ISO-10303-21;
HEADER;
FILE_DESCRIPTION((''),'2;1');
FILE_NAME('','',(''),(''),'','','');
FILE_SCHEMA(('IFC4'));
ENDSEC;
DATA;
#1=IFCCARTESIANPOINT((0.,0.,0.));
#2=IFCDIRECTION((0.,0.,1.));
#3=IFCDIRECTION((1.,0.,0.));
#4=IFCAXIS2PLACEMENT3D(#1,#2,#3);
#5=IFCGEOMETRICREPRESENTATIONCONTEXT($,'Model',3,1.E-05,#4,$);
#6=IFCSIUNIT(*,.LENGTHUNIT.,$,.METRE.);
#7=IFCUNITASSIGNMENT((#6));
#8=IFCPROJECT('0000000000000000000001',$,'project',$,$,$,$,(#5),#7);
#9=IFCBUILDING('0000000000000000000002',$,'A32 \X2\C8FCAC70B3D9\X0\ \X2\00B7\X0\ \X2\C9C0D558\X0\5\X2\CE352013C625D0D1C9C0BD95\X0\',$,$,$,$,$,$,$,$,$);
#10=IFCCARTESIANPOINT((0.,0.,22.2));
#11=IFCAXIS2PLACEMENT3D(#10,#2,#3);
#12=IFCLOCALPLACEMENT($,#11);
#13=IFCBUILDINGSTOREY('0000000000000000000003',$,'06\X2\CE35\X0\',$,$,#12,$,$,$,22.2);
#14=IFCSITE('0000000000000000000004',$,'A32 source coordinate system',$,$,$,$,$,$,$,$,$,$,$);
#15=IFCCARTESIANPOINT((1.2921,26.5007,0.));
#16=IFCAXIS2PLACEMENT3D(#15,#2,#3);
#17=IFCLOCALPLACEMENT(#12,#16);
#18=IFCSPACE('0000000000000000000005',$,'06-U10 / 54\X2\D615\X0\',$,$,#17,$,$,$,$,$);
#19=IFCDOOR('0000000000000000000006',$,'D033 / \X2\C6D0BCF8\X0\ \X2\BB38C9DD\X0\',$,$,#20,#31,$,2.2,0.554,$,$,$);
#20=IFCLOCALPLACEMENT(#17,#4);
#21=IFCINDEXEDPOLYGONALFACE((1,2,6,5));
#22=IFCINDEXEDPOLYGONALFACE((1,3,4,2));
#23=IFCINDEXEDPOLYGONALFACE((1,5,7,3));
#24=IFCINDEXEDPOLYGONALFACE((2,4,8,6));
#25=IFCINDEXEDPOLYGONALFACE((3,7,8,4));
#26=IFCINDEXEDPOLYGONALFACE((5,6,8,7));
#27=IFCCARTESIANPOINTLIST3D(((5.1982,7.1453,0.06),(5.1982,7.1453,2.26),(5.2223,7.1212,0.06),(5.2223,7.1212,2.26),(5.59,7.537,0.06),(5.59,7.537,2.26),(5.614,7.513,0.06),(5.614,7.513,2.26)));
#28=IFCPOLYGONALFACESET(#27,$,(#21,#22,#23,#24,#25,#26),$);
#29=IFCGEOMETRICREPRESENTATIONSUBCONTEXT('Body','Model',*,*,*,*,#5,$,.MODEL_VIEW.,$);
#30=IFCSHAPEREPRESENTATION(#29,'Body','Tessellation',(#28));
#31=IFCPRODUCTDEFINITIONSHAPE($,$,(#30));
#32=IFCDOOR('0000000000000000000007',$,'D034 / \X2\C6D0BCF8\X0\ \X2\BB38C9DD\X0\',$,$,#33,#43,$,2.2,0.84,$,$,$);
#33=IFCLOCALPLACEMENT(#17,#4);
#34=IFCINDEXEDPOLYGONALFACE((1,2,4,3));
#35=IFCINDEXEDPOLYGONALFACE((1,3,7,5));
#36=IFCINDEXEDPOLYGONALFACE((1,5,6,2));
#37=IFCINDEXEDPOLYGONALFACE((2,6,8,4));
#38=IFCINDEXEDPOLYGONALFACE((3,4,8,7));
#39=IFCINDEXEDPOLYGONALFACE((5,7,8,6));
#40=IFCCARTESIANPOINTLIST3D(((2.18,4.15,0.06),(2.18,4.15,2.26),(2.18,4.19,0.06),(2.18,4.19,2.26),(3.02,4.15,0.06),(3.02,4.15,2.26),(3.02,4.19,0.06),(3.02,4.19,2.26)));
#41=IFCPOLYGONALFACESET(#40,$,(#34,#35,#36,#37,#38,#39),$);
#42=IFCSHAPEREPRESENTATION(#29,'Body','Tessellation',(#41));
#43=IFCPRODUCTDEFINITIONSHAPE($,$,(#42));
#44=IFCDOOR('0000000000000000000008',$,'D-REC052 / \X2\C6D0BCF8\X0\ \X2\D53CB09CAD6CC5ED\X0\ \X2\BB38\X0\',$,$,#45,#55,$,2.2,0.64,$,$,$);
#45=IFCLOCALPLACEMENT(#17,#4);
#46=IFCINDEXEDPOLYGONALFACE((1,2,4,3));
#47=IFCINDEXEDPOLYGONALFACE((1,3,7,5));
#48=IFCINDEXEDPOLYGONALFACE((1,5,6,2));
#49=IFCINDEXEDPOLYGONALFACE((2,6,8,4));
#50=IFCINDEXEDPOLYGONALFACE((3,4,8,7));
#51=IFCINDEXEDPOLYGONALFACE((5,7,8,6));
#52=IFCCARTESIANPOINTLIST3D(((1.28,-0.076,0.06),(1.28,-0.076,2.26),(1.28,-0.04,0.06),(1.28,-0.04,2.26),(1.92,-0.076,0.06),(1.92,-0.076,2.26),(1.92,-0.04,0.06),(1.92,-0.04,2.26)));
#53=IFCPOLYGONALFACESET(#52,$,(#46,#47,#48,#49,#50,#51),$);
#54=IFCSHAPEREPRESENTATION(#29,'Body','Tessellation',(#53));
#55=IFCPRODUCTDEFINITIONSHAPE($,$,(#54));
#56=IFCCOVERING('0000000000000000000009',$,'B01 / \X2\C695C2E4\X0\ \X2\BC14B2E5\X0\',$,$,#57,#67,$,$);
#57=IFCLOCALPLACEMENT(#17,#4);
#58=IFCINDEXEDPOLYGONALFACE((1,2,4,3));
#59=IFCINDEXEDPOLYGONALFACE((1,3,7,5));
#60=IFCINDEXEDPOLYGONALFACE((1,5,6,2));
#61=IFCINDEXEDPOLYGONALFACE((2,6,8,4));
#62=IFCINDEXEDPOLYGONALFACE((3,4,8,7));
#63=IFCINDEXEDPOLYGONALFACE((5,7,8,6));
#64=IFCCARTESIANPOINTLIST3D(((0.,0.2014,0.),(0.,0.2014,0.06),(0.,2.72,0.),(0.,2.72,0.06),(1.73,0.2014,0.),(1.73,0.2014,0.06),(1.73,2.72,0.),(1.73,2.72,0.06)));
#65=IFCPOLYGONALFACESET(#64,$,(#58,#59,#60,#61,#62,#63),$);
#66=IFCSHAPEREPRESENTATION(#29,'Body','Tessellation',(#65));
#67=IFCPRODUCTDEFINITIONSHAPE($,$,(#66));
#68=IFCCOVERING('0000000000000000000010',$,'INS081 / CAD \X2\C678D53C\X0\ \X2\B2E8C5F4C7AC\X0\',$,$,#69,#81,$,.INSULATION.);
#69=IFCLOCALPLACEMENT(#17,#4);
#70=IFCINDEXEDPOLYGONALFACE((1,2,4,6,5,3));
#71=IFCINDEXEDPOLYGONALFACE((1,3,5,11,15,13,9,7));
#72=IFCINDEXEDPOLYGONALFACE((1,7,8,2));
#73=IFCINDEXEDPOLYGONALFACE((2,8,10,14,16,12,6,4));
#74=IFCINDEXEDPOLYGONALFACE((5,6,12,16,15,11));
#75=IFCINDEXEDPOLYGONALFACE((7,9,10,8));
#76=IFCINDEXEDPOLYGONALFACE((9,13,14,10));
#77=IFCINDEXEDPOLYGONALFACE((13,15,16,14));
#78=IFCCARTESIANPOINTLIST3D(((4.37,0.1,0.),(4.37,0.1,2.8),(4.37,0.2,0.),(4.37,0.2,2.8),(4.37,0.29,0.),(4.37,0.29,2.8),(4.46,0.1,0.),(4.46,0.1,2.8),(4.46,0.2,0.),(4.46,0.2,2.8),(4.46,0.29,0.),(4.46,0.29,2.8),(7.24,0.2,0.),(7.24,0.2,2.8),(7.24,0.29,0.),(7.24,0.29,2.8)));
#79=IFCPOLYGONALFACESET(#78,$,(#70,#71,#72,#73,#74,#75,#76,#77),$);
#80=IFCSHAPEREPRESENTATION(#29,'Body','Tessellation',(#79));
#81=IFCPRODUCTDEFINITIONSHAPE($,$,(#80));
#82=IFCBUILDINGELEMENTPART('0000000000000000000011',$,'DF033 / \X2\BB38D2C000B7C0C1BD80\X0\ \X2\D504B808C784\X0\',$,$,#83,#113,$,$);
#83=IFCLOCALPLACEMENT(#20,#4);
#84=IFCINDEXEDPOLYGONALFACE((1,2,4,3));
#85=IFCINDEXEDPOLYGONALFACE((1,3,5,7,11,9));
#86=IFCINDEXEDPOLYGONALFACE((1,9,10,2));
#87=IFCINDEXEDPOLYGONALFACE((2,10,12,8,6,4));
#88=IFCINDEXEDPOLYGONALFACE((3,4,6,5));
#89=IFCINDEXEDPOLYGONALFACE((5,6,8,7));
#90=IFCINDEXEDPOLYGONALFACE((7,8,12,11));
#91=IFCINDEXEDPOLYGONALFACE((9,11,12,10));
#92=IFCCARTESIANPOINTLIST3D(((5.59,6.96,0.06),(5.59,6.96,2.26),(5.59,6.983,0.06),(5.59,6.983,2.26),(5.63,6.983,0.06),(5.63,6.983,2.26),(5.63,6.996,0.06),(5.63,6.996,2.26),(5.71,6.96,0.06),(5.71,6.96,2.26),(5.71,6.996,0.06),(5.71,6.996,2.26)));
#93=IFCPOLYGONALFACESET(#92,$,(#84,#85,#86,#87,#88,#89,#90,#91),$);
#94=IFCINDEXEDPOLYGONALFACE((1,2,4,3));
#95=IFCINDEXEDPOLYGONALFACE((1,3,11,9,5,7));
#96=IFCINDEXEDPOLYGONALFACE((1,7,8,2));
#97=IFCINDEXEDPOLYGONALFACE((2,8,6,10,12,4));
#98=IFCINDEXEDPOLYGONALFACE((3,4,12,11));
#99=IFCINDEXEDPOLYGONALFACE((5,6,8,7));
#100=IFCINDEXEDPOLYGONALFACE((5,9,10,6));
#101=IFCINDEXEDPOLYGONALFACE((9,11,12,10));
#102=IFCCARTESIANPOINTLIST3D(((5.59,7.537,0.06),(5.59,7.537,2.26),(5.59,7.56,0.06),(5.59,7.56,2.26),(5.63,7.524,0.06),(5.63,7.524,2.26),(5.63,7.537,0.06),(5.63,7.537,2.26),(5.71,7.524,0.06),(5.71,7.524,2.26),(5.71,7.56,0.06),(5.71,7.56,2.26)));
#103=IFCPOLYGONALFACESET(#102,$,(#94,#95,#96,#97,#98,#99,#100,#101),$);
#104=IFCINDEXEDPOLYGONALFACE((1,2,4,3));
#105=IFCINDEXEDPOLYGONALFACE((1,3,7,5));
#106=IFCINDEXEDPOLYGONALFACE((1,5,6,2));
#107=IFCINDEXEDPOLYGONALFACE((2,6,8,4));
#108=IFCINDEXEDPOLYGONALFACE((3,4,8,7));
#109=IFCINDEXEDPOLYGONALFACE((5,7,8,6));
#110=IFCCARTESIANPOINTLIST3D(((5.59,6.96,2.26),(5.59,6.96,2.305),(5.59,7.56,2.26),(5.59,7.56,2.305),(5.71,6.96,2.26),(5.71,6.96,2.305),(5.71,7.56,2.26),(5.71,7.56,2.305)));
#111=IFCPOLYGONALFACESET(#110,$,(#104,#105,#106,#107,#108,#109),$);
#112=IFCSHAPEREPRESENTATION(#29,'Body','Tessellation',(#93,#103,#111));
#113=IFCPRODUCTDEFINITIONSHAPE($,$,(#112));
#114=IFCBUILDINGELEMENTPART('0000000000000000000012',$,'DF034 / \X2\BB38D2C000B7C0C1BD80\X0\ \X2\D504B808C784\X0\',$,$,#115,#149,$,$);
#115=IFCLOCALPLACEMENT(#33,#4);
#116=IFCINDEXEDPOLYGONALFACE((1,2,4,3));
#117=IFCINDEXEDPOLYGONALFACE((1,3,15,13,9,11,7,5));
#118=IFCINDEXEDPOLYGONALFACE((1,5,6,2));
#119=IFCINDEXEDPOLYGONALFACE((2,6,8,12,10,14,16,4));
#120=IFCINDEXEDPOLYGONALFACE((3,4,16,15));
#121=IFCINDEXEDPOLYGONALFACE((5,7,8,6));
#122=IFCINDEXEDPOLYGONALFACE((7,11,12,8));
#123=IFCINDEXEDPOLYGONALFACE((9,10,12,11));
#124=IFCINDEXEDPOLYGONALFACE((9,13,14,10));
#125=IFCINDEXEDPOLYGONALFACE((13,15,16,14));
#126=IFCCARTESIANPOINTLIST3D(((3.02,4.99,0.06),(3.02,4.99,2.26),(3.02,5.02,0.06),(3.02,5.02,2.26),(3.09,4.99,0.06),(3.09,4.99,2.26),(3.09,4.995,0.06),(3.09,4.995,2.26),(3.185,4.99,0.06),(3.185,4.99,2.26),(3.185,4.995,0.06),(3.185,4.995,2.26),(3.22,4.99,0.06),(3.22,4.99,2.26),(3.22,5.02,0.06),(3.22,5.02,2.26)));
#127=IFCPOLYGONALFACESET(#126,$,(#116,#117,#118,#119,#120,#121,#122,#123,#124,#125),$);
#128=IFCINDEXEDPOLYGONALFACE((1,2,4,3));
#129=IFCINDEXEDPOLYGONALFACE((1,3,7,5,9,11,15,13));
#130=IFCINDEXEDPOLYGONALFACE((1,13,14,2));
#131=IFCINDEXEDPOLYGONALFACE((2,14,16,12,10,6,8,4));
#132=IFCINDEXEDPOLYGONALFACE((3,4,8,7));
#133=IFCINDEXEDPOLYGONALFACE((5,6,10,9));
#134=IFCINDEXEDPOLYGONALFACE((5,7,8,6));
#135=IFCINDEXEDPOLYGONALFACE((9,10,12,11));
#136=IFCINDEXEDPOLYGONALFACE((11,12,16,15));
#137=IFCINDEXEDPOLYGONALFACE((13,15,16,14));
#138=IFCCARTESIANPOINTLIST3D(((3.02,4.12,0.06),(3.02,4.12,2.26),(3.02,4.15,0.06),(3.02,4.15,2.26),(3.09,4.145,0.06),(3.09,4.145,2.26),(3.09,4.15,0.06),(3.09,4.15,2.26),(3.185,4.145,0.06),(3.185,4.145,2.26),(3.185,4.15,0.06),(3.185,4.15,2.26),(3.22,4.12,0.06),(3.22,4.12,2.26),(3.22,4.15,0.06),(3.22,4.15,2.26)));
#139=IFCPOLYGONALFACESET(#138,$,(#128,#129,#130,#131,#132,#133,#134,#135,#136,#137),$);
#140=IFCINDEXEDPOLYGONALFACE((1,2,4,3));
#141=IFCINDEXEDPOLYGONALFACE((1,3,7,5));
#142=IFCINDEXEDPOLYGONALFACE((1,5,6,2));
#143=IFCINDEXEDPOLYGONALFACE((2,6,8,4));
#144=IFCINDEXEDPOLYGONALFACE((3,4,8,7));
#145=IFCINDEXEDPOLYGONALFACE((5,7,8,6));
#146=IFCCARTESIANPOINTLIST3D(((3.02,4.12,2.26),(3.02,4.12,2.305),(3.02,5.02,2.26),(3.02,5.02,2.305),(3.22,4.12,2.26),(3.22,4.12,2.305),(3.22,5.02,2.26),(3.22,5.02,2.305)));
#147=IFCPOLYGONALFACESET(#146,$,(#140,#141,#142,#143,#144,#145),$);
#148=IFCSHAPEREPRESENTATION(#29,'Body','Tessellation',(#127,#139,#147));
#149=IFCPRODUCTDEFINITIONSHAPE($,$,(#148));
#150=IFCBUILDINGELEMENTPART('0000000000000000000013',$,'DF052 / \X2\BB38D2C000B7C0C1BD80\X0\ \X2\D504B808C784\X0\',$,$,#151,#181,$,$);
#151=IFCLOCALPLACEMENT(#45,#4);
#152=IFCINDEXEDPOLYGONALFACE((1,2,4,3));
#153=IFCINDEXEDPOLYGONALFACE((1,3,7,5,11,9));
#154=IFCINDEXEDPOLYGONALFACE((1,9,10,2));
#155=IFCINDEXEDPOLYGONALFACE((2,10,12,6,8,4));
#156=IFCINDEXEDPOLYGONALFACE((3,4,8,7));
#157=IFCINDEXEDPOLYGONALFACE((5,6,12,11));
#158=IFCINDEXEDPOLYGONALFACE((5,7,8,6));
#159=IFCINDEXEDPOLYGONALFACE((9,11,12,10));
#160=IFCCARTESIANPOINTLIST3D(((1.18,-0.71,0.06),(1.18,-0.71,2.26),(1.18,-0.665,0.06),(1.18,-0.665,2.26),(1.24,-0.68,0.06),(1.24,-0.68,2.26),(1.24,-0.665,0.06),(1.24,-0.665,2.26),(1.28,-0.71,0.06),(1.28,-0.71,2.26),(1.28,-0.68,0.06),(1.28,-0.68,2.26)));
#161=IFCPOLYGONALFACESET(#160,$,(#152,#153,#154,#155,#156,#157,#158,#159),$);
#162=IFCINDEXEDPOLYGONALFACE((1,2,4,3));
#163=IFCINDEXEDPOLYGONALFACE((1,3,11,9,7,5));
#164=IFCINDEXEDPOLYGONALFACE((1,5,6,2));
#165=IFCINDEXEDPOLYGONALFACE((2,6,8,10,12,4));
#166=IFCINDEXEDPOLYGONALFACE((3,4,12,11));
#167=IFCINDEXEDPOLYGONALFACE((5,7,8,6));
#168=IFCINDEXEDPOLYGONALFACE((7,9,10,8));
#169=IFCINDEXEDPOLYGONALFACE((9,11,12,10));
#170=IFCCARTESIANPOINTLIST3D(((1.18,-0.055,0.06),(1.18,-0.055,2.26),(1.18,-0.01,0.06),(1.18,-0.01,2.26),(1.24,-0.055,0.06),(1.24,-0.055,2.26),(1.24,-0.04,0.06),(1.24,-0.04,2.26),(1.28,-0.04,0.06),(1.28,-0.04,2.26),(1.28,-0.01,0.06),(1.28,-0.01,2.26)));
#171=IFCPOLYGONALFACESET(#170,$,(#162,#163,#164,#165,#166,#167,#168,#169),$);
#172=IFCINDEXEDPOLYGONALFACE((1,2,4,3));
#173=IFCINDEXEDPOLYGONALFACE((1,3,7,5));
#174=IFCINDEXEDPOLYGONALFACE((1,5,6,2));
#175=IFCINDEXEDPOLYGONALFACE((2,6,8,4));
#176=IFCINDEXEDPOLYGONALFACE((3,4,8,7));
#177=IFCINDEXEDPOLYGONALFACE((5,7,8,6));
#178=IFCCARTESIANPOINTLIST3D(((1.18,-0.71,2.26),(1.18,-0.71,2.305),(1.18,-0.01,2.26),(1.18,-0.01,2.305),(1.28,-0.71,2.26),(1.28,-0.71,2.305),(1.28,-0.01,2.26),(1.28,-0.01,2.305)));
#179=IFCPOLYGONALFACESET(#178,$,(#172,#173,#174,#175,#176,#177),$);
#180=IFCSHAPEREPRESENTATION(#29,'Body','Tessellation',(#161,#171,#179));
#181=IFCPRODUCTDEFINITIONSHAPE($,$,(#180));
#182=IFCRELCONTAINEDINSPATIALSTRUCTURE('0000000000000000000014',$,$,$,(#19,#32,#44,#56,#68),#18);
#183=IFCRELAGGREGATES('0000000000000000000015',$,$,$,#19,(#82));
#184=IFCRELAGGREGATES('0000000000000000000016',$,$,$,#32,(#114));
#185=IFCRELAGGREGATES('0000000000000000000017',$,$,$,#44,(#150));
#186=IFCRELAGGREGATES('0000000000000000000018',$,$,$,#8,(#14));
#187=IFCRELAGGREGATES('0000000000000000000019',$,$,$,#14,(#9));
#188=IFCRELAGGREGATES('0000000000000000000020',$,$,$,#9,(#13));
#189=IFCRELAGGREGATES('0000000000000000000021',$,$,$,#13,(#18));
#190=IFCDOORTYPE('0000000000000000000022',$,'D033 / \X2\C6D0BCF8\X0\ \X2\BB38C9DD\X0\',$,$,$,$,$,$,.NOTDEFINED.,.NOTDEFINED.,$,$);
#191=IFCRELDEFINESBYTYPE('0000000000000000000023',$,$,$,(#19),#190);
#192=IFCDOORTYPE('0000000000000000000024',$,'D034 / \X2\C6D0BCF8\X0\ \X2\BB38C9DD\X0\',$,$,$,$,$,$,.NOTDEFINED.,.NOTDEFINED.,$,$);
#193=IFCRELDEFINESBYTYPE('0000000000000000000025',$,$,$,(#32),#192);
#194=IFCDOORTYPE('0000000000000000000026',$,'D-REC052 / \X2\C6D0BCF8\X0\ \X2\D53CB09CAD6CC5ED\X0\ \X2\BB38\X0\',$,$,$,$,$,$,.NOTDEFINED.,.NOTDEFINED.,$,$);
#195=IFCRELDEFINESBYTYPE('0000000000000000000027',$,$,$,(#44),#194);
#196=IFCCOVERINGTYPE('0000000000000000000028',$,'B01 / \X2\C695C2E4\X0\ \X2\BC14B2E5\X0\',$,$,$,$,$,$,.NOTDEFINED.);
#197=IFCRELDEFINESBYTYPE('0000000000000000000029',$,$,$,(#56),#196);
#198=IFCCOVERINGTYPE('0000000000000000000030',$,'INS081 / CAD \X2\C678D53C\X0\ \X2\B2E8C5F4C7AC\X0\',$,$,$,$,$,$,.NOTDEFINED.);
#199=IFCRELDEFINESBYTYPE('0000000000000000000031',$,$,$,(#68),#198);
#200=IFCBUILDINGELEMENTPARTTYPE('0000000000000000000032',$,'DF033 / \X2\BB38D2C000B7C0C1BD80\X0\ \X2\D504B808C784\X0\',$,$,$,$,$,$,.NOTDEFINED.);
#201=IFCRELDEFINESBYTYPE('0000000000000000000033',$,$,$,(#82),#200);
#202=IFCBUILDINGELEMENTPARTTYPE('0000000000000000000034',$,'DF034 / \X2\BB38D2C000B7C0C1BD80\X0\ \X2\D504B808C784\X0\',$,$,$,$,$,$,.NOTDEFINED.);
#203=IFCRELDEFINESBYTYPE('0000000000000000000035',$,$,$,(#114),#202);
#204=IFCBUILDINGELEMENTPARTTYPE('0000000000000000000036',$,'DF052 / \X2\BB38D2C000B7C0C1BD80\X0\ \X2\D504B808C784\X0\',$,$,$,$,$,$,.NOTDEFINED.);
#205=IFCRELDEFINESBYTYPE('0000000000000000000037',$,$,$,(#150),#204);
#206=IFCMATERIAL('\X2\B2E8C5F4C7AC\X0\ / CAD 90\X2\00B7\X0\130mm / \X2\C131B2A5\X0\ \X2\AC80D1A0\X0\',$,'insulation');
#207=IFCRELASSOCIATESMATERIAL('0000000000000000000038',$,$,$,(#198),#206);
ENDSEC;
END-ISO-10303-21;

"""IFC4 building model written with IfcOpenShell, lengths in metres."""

from ifc_helpers import new_model, si_unit, frame, origin, origin_with_axes, place, context, subcontext, project, spatial, polyline, outline, extrude, source, transform, mapped, material, type_object, type_shapes, element, aggregate, save


model = new_model("IFC4")

# Units and contexts
model_context = context("Model", 3, precision=1e-05, world=origin_with_axes())
body_context = subcontext(model_context, "Body", "Model", "MODEL_VIEW")
ifc_project = project(units=[si_unit("LENGTHUNIT", "METRE")], contexts=[model_context])

# Site, building, storey, space
storey_placement = place(None, frame((0.0, 0.0, 22.2), z_axis=(0.0, 0.0, 1.0), x_axis=(1.0, 0.0, 0.0)))
space_placement = place(storey_placement, frame((1.2921, 26.5007, 0.0), z_axis=(0.0, 0.0, 1.0), x_axis=(1.0, 0.0, 0.0)))
site = spatial("IfcSite", under=ifc_project, Name="A32 source coordinate system")
building = spatial("IfcBuilding", under=site, Name="A32 주거동 · 지하5층–옥탑지붕")
storey = spatial("IfcBuildingStorey", under=building, at=storey_placement, Name="06층", Elevation=22.2)
space = spatial("IfcSpace", under=storey, at=space_placement, Name="06-U10 / 54형")

# Doors
door_type_1 = type_object("IfcDoorType", Name="D033 / 원본 문짝", OperationType="NOTDEFINED", PredefinedType="NOTDEFINED")
shared_shape_1 = source(origin(), body_context, "Body", "SweptSolid", [
    extrude(outline(polyline([(5.2223, 7.1212), (5.1982, 7.1453), (5.59, 7.537), (5.614, 7.513), (5.2223, 7.1212)])), frame((0.0, 0.0, 0.06)), (0.0, 0.0, 1.0), 2.2),
])
type_shapes(door_type_1, [shared_shape_1])
door_1_placement = place(space_placement, origin_with_axes())
door_1 = element("IfcDoor", 1, at=door_1_placement, inside=space, type_object=door_type_1, Name="D033 / 원본 문짝", OverallHeight=2.2, OverallWidth=0.554, context=body_context, shape_type="MappedRepresentation", body=[
    mapped(shared_shape_1, transform((0.0, 0.0, 0.0), scale=1.0)),
])
door_type_2 = type_object("IfcDoorType", Name="D034 / 원본 문짝", OperationType="NOTDEFINED", PredefinedType="NOTDEFINED")
shared_shape_2 = source(origin(), body_context, "Body", "SweptSolid", [
    extrude(outline(polyline([(3.02, 4.15), (2.18, 4.15), (2.18, 4.19), (3.02, 4.19), (3.02, 4.15)])), frame((0.0, 0.0, 0.06)), (0.0, 0.0, 1.0), 2.2),
])
type_shapes(door_type_2, [shared_shape_2])
door_2_placement = place(space_placement, origin_with_axes())
door_2 = element("IfcDoor", 2, at=door_2_placement, inside=space, type_object=door_type_2, Name="D034 / 원본 문짝", OverallHeight=2.2, OverallWidth=0.84, context=body_context, shape_type="MappedRepresentation", body=[
    mapped(shared_shape_2, transform((0.0, 0.0, 0.0), scale=1.0)),
])
door_type_3 = type_object("IfcDoorType", Name="D-REC052 / 원본 피난구역 문", OperationType="NOTDEFINED", PredefinedType="NOTDEFINED")
shared_shape_3 = source(origin(), body_context, "Body", "SweptSolid", [
    extrude(outline(polyline([(1.92, -0.076), (1.28, -0.076), (1.28, -0.04), (1.92, -0.04), (1.92, -0.076)])), frame((0.0, 0.0, 0.06)), (0.0, 0.0, 1.0), 2.2),
])
type_shapes(door_type_3, [shared_shape_3])
door_3_placement = place(space_placement, origin_with_axes())
door_3 = element("IfcDoor", 3, at=door_3_placement, inside=space, type_object=door_type_3, Name="D-REC052 / 원본 피난구역 문", OverallHeight=2.2, OverallWidth=0.64, context=body_context, shape_type="MappedRepresentation", body=[
    mapped(shared_shape_3, transform((0.0, 0.0, 0.0), scale=1.0)),
])

# Coverings
covering_type_1 = type_object("IfcCoveringType", Name="B01 / 욕실 바닥", PredefinedType="NOTDEFINED")
shared_shape_4 = source(origin(), body_context, "Body", "SweptSolid", [
    extrude(outline(polyline([(0.0, 0.2014), (0.0, 2.72), (1.73, 2.72), (1.73, 0.2014), (0.0, 0.2014)])), origin(), (0.0, 0.0, 1.0), 0.06),
])
type_shapes(covering_type_1, [shared_shape_4])
covering_1_placement = place(space_placement, origin_with_axes())
element("IfcCovering", 4, at=covering_1_placement, inside=space, type_object=covering_type_1, Name="B01 / 욕실 바닥", context=body_context, shape_type="MappedRepresentation", body=[
    mapped(shared_shape_4, transform((0.0, 0.0, 0.0), scale=1.0)),
])
ifc_material = material(Name="단열재 / CAD 90·130mm / 성능 검토", Category="insulation")
covering_type_2 = type_object("IfcCoveringType", Name="INS081 / CAD 외피 단열재", PredefinedType="NOTDEFINED", material=ifc_material)
shared_shape_5 = source(origin(), body_context, "Body", "SweptSolid", [
    extrude(outline(polyline([(4.37, 0.2), (4.37, 0.29), (4.46, 0.29), (7.24, 0.29), (7.24, 0.2), (4.46, 0.2), (4.46, 0.1), (4.37, 0.1), (4.37, 0.2)])), origin(), (0.0, 0.0, 1.0), 2.8),
])
type_shapes(covering_type_2, [shared_shape_5])
covering_2_placement = place(space_placement, origin_with_axes())
element("IfcCovering", 5, at=covering_2_placement, inside=space, type_object=covering_type_2, Name="INS081 / CAD 외피 단열재", PredefinedType="INSULATION", context=body_context, shape_type="MappedRepresentation", body=[
    mapped(shared_shape_5, transform((0.0, 0.0, 0.0), scale=1.0)),
])

# Building element parts
building_element_part_type_1 = type_object("IfcBuildingElementPartType", Name="DF033 / 문틀·상부 프레임", PredefinedType="NOTDEFINED")
shared_shape_6 = source(origin(), body_context, "Body", "SweptSolid", [
    extrude(outline(polyline([(5.59, 6.96), (5.59, 6.983), (5.63, 6.983), (5.63, 6.996), (5.71, 6.996), (5.71, 6.96), (5.59, 6.96)])), frame((0.0, 0.0, 0.06)), (0.0, 0.0, 1.0), 2.2),
    extrude(outline(polyline([(5.71, 7.524), (5.63, 7.524), (5.63, 7.537), (5.59, 7.537), (5.59, 7.56), (5.71, 7.56), (5.71, 7.524)])), frame((0.0, 0.0, 0.06)), (0.0, 0.0, 1.0), 2.2),
    extrude(outline(polyline([(5.59, 6.96), (5.59, 7.56), (5.71, 7.56), (5.71, 6.96), (5.59, 6.96)])), frame((0.0, 0.0, 2.26)), (0.0, 0.0, 1.0), 0.045),
])
type_shapes(building_element_part_type_1, [shared_shape_6])
building_element_part_1_placement = place(door_1_placement, origin_with_axes())
building_element_part_1 = element("IfcBuildingElementPart", 6, at=building_element_part_1_placement, type_object=building_element_part_type_1, Name="DF033 / 문틀·상부 프레임", context=body_context, shape_type="MappedRepresentation", body=[
    mapped(shared_shape_6, transform((0.0, 0.0, 0.0), scale=1.0)),
])
aggregate(door_1, [building_element_part_1])
building_element_part_type_2 = type_object("IfcBuildingElementPartType", Name="DF034 / 문틀·상부 프레임", PredefinedType="NOTDEFINED")
shared_shape_7 = source(origin(), body_context, "Body", "SweptSolid", [
    extrude(outline(polyline([(3.22, 5.02), (3.22, 4.99), (3.185, 4.99), (3.185, 4.995), (3.09, 4.995), (3.09, 4.99), (3.02, 4.99), (3.02, 5.02), (3.22, 5.02)])), frame((0.0, 0.0, 0.06)), (0.0, 0.0, 1.0), 2.2),
    extrude(outline(polyline([(3.02, 4.15), (3.09, 4.15), (3.09, 4.145), (3.185, 4.145), (3.185, 4.15), (3.22, 4.15), (3.22, 4.12), (3.02, 4.12), (3.02, 4.15)])), frame((0.0, 0.0, 0.06)), (0.0, 0.0, 1.0), 2.2),
    extrude(outline(polyline([(3.02, 4.12), (3.02, 5.02), (3.22, 5.02), (3.22, 4.12), (3.02, 4.12)])), frame((0.0, 0.0, 2.26)), (0.0, 0.0, 1.0), 0.045),
])
type_shapes(building_element_part_type_2, [shared_shape_7])
building_element_part_2_placement = place(door_2_placement, origin_with_axes())
building_element_part_2 = element("IfcBuildingElementPart", 7, at=building_element_part_2_placement, type_object=building_element_part_type_2, Name="DF034 / 문틀·상부 프레임", context=body_context, shape_type="MappedRepresentation", body=[
    mapped(shared_shape_7, transform((0.0, 0.0, 0.0), scale=1.0)),
])
aggregate(door_2, [building_element_part_2])
building_element_part_type_3 = type_object("IfcBuildingElementPartType", Name="DF052 / 문틀·상부 프레임", PredefinedType="NOTDEFINED")
shared_shape_8 = source(origin(), body_context, "Body", "SweptSolid", [
    extrude(outline(polyline([(1.18, -0.71), (1.18, -0.665), (1.24, -0.665), (1.24, -0.68), (1.28, -0.68), (1.28, -0.71), (1.18, -0.71)])), frame((0.0, 0.0, 0.06)), (0.0, 0.0, 1.0), 2.2),
    extrude(outline(polyline([(1.28, -0.04), (1.24, -0.04), (1.24, -0.055), (1.18, -0.055), (1.18, -0.01), (1.28, -0.01), (1.28, -0.04)])), frame((0.0, 0.0, 0.06)), (0.0, 0.0, 1.0), 2.2),
    extrude(outline(polyline([(1.18, -0.71), (1.18, -0.01), (1.28, -0.01), (1.28, -0.71), (1.18, -0.71)])), frame((0.0, 0.0, 2.26)), (0.0, 0.0, 1.0), 0.045),
])
type_shapes(building_element_part_type_3, [shared_shape_8])
building_element_part_3_placement = place(door_3_placement, origin_with_axes())
building_element_part_3 = element("IfcBuildingElementPart", 8, at=building_element_part_3_placement, type_object=building_element_part_type_3, Name="DF052 / 문틀·상부 프레임", context=body_context, shape_type="MappedRepresentation", body=[
    mapped(shared_shape_8, transform((0.0, 0.0, 0.0), scale=1.0)),
])
aggregate(door_3, [building_element_part_3])

save(model, "model.ifc")
